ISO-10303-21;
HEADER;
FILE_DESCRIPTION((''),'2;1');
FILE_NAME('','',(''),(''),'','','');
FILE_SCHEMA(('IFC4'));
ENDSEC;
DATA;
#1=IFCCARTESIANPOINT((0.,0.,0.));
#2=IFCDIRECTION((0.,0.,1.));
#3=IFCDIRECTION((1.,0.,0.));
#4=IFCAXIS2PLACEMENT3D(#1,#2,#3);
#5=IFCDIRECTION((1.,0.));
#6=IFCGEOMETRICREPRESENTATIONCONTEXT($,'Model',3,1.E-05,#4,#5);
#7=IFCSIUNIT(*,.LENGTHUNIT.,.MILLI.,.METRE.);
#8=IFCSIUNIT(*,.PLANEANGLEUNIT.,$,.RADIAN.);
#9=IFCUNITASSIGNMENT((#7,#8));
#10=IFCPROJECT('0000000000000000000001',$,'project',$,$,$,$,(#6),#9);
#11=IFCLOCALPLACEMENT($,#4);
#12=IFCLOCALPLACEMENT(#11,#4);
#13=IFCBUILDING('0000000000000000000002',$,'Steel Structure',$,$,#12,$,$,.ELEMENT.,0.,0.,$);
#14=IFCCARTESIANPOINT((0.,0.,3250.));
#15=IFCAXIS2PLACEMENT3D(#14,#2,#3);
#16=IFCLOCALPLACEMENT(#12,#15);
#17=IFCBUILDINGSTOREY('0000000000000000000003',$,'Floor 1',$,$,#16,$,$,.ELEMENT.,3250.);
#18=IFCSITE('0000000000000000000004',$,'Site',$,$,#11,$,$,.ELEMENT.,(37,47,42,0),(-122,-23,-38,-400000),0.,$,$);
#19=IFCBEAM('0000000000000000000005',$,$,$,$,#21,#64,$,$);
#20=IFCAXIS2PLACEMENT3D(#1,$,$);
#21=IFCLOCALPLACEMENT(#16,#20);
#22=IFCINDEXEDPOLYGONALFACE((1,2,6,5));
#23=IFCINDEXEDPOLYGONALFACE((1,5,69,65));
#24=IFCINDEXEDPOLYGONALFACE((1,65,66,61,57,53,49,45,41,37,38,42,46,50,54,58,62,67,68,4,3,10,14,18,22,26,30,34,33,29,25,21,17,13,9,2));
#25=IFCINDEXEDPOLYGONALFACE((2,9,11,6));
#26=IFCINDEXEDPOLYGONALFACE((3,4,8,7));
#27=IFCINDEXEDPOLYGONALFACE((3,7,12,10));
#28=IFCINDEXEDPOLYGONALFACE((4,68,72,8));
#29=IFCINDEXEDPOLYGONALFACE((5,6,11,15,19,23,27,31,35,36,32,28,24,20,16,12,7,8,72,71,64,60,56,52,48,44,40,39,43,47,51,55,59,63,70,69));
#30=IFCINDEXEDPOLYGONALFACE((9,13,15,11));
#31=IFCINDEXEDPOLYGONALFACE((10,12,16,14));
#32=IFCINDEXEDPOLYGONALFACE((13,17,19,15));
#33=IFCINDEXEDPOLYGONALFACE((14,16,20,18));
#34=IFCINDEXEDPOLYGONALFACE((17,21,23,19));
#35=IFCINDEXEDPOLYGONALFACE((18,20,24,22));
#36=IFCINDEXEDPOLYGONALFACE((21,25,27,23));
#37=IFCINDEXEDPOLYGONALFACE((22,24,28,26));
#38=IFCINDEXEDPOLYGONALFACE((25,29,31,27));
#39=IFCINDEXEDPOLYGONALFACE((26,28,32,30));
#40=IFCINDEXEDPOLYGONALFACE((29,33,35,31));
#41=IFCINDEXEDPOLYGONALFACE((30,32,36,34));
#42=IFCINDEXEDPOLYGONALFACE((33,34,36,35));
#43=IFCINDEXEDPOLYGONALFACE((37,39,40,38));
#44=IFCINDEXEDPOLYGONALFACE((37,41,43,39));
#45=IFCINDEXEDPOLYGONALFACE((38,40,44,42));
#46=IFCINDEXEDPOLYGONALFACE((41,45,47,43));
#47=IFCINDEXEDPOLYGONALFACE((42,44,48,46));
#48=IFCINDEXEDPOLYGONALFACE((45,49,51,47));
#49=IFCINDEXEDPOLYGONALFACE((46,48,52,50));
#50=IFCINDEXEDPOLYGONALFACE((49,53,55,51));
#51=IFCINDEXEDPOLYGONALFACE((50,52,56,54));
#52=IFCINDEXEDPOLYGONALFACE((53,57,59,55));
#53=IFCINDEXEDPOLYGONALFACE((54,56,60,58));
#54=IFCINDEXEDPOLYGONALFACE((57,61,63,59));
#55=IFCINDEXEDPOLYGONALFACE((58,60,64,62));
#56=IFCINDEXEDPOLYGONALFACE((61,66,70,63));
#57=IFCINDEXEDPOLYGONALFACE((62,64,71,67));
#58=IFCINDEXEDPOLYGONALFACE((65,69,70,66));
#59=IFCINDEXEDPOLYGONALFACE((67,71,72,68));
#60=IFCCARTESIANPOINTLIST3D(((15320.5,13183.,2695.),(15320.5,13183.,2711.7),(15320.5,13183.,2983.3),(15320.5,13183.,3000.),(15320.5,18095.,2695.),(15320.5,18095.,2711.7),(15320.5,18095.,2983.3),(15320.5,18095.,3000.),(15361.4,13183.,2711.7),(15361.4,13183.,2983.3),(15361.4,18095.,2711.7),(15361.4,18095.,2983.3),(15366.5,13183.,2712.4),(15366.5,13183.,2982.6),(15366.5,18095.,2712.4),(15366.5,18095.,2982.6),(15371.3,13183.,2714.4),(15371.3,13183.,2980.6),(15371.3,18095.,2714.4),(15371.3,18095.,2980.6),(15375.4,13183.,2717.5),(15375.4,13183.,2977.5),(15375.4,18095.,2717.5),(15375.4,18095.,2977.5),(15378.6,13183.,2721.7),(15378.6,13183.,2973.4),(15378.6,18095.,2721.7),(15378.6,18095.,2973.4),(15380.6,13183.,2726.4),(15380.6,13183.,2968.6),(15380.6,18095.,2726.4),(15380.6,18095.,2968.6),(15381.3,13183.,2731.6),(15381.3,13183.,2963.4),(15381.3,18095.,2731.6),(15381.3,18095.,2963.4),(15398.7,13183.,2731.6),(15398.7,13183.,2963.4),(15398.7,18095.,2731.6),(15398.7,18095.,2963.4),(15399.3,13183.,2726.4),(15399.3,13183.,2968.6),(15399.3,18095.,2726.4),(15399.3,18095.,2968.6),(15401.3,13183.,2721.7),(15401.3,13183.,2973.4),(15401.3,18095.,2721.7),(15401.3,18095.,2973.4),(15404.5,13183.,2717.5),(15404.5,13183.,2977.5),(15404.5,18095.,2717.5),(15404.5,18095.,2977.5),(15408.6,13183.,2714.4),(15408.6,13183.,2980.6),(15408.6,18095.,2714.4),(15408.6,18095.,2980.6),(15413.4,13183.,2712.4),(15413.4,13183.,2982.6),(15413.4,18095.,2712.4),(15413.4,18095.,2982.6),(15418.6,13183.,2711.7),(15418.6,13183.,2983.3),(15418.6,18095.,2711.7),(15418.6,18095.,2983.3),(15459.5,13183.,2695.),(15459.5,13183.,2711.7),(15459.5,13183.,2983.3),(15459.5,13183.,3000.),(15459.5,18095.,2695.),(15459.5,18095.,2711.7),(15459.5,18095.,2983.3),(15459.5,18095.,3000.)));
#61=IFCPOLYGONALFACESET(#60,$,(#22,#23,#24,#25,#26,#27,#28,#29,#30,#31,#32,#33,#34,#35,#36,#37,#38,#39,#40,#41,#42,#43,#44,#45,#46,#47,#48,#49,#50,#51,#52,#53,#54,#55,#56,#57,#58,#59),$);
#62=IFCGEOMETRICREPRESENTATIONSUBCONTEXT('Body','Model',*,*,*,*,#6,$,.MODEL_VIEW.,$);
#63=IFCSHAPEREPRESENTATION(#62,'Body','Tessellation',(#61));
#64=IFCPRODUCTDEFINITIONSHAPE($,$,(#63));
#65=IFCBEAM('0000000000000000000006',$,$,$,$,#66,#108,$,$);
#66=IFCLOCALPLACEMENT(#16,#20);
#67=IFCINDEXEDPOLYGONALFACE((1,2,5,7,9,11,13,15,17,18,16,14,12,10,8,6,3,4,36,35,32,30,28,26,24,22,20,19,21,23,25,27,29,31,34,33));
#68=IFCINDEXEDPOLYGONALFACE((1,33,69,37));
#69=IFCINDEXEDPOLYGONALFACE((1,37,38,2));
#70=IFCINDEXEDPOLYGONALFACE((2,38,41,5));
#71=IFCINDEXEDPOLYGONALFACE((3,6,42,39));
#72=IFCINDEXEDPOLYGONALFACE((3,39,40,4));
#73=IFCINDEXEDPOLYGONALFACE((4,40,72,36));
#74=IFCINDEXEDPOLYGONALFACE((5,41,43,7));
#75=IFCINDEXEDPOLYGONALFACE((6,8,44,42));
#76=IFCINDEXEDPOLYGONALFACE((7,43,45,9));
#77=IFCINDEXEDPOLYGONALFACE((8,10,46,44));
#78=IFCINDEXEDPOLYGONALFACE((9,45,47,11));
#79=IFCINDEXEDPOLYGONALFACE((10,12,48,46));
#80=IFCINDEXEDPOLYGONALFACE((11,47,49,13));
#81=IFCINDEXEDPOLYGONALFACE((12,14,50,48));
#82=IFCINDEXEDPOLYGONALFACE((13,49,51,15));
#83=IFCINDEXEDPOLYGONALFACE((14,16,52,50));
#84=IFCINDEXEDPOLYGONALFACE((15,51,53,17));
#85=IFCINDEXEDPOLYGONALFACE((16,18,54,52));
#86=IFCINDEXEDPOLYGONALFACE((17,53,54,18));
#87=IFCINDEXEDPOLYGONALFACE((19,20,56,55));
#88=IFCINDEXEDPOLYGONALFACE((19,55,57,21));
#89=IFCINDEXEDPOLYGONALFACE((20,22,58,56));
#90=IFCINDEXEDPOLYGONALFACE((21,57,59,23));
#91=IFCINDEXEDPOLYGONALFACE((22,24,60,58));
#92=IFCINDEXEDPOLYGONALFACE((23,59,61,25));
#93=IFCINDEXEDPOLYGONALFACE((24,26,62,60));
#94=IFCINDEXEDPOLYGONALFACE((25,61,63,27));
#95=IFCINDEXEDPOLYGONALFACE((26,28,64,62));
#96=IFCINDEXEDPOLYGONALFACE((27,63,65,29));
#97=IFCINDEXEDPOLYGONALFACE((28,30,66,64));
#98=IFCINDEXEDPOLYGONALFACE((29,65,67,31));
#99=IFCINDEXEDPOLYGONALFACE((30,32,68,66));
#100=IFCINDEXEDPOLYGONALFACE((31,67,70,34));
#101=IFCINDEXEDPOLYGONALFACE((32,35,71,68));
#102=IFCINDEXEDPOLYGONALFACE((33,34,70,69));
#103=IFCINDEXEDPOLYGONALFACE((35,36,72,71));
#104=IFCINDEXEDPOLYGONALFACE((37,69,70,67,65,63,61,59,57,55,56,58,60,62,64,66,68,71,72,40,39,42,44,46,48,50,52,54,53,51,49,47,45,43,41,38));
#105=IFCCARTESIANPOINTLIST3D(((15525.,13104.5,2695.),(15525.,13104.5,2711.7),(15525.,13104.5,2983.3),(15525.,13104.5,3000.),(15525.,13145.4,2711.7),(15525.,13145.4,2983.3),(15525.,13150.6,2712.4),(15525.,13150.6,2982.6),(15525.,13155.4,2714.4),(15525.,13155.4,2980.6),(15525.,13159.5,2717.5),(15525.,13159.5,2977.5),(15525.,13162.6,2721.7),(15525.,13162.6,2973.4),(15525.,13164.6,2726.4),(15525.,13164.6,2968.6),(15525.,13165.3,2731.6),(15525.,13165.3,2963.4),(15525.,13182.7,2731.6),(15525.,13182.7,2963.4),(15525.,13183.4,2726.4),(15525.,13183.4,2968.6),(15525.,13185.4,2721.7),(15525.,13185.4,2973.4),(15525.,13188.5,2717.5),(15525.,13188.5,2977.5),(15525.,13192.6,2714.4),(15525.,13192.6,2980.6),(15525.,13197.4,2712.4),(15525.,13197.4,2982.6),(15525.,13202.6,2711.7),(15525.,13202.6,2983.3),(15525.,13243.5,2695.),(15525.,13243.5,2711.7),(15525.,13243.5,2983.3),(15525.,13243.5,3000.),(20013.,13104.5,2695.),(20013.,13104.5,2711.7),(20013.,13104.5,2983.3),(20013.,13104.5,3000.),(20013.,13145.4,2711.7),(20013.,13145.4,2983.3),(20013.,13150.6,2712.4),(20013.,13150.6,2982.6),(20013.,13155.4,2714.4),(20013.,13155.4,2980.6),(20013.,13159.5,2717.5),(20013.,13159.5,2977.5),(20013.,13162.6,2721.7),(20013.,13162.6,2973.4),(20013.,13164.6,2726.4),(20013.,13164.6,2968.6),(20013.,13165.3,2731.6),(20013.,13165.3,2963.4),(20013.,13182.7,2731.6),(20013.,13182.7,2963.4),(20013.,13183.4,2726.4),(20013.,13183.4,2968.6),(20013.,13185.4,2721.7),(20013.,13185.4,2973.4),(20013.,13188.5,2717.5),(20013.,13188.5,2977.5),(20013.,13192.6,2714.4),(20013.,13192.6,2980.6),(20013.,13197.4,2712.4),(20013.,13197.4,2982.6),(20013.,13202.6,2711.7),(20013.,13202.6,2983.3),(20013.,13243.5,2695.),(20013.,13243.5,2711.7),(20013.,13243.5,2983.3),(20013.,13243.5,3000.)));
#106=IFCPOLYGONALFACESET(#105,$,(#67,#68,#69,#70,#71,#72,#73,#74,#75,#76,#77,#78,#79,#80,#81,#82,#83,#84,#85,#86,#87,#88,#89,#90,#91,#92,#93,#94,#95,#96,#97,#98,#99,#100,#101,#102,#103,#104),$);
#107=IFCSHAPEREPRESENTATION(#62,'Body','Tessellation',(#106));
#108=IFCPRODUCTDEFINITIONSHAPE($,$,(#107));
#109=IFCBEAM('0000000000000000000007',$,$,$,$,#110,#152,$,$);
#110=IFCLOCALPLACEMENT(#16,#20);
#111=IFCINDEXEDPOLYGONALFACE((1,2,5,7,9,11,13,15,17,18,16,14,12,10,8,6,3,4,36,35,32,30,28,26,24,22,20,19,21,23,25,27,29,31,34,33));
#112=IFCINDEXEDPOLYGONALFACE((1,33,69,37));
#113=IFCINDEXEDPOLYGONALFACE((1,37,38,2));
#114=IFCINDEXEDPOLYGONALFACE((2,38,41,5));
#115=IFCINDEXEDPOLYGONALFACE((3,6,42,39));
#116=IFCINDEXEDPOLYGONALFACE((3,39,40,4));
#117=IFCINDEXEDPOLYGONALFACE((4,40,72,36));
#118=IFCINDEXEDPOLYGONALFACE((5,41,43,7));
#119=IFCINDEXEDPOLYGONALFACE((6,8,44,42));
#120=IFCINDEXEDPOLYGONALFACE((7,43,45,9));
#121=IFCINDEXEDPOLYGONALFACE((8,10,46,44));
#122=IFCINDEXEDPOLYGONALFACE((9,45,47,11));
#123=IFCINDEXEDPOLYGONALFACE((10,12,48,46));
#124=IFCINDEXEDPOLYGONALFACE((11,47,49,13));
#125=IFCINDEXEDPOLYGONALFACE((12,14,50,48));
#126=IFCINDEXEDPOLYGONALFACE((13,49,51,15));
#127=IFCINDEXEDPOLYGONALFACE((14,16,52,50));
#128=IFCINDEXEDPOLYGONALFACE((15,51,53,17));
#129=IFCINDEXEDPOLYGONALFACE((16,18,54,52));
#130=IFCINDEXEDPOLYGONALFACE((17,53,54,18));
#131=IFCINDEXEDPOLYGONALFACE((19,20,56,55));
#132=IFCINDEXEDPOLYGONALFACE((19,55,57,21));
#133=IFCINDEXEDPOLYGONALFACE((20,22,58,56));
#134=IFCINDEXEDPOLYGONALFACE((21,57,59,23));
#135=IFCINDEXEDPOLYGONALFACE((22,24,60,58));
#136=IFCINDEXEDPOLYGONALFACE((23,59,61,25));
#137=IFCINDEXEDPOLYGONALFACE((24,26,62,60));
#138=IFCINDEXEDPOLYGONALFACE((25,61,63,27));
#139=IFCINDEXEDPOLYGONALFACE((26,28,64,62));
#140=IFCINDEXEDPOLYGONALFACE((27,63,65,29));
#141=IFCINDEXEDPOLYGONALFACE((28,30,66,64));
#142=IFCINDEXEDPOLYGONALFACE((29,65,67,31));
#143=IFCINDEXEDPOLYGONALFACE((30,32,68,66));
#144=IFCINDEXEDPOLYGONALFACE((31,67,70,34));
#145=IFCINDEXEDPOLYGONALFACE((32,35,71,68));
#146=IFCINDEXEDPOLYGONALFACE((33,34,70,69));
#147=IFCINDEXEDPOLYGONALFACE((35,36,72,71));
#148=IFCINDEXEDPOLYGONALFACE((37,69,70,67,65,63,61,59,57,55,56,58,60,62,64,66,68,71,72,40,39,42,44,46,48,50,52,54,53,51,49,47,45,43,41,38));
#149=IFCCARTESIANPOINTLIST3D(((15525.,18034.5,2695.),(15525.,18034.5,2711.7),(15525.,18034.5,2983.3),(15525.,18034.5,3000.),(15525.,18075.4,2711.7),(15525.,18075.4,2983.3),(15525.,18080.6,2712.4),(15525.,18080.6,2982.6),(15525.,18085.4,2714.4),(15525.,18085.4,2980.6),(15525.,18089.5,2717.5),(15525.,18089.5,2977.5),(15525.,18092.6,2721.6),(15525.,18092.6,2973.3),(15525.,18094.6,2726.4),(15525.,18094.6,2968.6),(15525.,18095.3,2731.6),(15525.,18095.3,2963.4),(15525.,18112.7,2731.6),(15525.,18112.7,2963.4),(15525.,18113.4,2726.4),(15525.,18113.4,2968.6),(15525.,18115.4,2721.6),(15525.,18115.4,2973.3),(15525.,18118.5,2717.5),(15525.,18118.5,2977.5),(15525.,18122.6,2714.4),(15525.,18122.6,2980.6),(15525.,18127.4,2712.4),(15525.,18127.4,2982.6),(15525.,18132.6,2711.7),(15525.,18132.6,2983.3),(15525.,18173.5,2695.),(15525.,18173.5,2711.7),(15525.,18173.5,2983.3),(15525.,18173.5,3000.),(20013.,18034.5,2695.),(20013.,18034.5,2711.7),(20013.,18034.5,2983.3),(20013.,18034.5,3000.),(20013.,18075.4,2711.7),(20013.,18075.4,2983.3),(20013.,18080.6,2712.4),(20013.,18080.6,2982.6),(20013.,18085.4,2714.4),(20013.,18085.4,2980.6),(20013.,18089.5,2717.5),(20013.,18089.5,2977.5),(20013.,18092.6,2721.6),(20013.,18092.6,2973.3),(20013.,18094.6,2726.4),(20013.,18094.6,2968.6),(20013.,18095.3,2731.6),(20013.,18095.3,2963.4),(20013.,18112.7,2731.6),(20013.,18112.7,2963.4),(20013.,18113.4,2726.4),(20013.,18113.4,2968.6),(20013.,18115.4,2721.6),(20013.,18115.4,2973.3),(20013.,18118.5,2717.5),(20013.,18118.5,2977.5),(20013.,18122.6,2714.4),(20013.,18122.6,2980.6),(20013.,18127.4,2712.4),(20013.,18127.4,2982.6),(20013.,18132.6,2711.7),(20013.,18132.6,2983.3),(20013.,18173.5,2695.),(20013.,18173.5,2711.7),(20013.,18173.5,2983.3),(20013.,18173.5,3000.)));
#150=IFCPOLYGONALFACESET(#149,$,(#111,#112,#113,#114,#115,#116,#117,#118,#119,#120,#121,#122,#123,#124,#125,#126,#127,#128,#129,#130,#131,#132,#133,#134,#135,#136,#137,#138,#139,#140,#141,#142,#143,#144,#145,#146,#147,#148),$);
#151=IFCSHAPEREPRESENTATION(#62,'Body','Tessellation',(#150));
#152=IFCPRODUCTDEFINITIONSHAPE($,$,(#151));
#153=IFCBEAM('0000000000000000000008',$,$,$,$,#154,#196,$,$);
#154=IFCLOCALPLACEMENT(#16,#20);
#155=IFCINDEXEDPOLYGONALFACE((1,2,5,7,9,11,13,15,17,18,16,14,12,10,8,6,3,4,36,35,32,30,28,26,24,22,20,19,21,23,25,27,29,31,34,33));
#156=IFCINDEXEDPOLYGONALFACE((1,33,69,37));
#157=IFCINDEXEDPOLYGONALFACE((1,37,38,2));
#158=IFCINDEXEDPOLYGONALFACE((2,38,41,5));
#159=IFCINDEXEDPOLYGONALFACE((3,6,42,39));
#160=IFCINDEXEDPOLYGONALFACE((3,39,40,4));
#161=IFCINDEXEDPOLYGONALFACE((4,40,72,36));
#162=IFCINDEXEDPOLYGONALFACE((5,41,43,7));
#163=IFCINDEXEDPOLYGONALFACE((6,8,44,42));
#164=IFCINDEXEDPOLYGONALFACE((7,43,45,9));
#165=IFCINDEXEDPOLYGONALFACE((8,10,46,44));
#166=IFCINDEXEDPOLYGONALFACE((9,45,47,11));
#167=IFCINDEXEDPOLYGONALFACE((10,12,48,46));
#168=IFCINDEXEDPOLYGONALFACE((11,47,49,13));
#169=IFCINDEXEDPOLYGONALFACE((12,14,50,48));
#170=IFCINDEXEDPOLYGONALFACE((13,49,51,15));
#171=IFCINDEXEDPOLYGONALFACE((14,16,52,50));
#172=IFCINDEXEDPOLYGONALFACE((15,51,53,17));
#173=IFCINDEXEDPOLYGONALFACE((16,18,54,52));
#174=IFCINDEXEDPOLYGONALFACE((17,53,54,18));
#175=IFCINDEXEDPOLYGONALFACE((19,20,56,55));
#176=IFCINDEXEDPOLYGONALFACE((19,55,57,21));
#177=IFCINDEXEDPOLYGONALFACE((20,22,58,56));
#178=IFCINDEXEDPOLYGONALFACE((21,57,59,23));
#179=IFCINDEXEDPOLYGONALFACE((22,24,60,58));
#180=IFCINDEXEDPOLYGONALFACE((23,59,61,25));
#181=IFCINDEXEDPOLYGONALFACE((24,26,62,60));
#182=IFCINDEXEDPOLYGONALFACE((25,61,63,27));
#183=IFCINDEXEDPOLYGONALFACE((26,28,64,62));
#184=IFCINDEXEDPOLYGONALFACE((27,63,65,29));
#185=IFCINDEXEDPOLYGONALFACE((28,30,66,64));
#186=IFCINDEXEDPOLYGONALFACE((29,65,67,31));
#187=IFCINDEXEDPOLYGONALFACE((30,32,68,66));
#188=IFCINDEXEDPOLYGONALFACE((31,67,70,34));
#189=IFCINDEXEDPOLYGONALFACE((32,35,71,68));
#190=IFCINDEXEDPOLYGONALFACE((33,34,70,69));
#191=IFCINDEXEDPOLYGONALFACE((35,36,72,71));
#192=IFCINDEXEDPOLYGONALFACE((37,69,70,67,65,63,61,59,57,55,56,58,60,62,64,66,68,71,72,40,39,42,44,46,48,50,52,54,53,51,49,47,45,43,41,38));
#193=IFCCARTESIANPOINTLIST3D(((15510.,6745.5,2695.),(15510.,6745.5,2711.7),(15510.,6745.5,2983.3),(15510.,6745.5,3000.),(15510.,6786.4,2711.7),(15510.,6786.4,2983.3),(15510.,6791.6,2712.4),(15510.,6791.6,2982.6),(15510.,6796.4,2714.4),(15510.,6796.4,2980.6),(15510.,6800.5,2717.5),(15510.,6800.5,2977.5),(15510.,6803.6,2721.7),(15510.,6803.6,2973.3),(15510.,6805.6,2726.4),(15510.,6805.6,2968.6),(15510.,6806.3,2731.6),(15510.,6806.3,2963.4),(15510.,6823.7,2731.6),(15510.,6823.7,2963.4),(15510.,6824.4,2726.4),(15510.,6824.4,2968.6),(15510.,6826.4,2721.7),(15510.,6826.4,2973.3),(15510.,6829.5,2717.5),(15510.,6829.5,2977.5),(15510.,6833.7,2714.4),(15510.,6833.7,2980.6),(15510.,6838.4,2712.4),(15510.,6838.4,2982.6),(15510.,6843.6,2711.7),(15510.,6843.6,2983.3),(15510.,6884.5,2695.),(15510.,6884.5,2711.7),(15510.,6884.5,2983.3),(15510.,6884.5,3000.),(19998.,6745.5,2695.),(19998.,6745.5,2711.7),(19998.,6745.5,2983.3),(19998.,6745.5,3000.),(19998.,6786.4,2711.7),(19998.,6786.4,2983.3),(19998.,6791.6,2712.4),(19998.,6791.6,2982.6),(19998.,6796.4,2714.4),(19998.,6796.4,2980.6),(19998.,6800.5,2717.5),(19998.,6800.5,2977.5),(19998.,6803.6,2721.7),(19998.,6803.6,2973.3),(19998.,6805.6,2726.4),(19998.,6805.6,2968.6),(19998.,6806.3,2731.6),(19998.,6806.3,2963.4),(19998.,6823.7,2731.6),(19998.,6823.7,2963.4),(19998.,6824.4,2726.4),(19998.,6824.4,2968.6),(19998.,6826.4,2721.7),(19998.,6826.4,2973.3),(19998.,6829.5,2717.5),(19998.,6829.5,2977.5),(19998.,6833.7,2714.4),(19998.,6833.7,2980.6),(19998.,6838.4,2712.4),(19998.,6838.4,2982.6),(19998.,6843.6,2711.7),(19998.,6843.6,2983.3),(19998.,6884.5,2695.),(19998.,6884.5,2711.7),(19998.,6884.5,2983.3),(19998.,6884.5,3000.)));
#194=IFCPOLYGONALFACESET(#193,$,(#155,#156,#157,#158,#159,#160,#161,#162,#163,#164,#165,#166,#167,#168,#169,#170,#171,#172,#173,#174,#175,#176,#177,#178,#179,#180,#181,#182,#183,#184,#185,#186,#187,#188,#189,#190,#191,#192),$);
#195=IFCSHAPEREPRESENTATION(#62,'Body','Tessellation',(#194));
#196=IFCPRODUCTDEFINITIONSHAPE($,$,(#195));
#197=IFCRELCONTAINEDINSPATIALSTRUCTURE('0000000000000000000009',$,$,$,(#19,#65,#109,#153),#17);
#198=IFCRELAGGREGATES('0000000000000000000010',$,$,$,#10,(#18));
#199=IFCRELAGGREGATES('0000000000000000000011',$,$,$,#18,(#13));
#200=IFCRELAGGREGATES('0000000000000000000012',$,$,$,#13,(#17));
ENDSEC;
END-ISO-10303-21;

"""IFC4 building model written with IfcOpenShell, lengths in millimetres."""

from ifc_helpers import new_model, si_unit, direction, frame, origin_with_axes, origin_2d_with_axis, place, context, subcontext, project, spatial, i_section, extrude, element, save


model = new_model("IFC4")

# Units and contexts
model_context = context("Model", 3, precision=1e-05, world=origin_with_axes(), true_north=direction((1.0, 0.0)))
body_context = subcontext(model_context, "Body", "Model", "MODEL_VIEW")
ifc_project = project(units=[si_unit("LENGTHUNIT", "METRE", prefix="MILLI"), si_unit("PLANEANGLEUNIT", "RADIAN")], contexts=[model_context])

# Site, building, storey
site_placement = place(None, origin_with_axes())
site = spatial("IfcSite", under=ifc_project, at=site_placement, Name="Site", CompositionType="ELEMENT", RefLatitude=(37, 47, 42, 0), RefLongitude=(-122, -23, -38, -400000), RefElevation=0.0)
building_placement = place(site_placement, origin_with_axes())
building = spatial("IfcBuilding", under=site, at=building_placement, Name="Steel Structure", CompositionType="ELEMENT", ElevationOfRefHeight=0.0, ElevationOfTerrain=0.0)
storey_placement = place(building_placement, frame((0.0, 0.0, 3250.0), z_axis=(0.0, 0.0, 1.0), x_axis=(1.0, 0.0, 0.0)))
storey = spatial("IfcBuildingStorey", under=building, at=storey_placement, Name="Floor 1", CompositionType="ELEMENT", Elevation=3250.0)

# Beams
beam_1_placement = place(storey_placement, frame((15390.0, 18095.0, 2695.0), z_axis=(0.0, -1.0, 0.0), x_axis=(1.0, 0.0, 0.0)))
element("IfcBeam", 1, at=beam_1_placement, inside=storey, context=body_context, shape_type="SweptSolid", body=[
    extrude(i_section(OverallWidth=139.0, OverallDepth=305.0, WebThickness=17.4, FlangeThickness=16.7, FilletRadius=19.9, at=origin_2d_with_axis()), frame((0.0, 152.5, 0.0), z_axis=(0.0, 0.0, 1.0), x_axis=(1.0, 0.0, 0.0)), (0.0, 0.0, 1.0), 4912.0),
])
beam_2_placement = place(storey_placement, frame((15525.0, 13174.0, 2695.0), z_axis=(1.0, 0.0, 0.0), x_axis=(0.0, 1.0, 0.0)))
element("IfcBeam", 2, at=beam_2_placement, inside=storey, context=body_context, shape_type="SweptSolid", body=[
    extrude(i_section(OverallWidth=139.0, OverallDepth=305.0, WebThickness=17.4, FlangeThickness=16.7, FilletRadius=19.9, at=origin_2d_with_axis()), frame((0.0, 152.5, 0.0), z_axis=(0.0, 0.0, 1.0), x_axis=(1.0, 0.0, 0.0)), (0.0, 0.0, 1.0), 4488.0),
])
beam_3_placement = place(storey_placement, frame((15525.0, 18104.0, 2695.0), z_axis=(1.0, 0.0, 0.0), x_axis=(0.0, 1.0, 0.0)))
element("IfcBeam", 3, at=beam_3_placement, inside=storey, context=body_context, shape_type="SweptSolid", body=[
    extrude(i_section(OverallWidth=139.0, OverallDepth=305.0, WebThickness=17.4, FlangeThickness=16.7, FilletRadius=19.9, at=origin_2d_with_axis()), frame((0.0, 152.5, 0.0), z_axis=(0.0, 0.0, 1.0), x_axis=(1.0, 0.0, 0.0)), (0.0, 0.0, 1.0), 4488.0),
])
beam_4_placement = place(storey_placement, frame((19998.0, 6815.0, 2695.0), z_axis=(-1.0, 0.0, 0.0), x_axis=(0.0, -1.0, 0.0)))
element("IfcBeam", 4, at=beam_4_placement, inside=storey, context=body_context, shape_type="SweptSolid", body=[
    extrude(i_section(OverallWidth=139.0, OverallDepth=305.0, WebThickness=17.4, FlangeThickness=16.7, FilletRadius=19.9, at=origin_2d_with_axis()), frame((0.0, 152.5, 0.0), z_axis=(0.0, 0.0, 1.0), x_axis=(1.0, 0.0, 0.0)), (0.0, 0.0, 1.0), 4488.0),
])

save(model, "model.ifc")
